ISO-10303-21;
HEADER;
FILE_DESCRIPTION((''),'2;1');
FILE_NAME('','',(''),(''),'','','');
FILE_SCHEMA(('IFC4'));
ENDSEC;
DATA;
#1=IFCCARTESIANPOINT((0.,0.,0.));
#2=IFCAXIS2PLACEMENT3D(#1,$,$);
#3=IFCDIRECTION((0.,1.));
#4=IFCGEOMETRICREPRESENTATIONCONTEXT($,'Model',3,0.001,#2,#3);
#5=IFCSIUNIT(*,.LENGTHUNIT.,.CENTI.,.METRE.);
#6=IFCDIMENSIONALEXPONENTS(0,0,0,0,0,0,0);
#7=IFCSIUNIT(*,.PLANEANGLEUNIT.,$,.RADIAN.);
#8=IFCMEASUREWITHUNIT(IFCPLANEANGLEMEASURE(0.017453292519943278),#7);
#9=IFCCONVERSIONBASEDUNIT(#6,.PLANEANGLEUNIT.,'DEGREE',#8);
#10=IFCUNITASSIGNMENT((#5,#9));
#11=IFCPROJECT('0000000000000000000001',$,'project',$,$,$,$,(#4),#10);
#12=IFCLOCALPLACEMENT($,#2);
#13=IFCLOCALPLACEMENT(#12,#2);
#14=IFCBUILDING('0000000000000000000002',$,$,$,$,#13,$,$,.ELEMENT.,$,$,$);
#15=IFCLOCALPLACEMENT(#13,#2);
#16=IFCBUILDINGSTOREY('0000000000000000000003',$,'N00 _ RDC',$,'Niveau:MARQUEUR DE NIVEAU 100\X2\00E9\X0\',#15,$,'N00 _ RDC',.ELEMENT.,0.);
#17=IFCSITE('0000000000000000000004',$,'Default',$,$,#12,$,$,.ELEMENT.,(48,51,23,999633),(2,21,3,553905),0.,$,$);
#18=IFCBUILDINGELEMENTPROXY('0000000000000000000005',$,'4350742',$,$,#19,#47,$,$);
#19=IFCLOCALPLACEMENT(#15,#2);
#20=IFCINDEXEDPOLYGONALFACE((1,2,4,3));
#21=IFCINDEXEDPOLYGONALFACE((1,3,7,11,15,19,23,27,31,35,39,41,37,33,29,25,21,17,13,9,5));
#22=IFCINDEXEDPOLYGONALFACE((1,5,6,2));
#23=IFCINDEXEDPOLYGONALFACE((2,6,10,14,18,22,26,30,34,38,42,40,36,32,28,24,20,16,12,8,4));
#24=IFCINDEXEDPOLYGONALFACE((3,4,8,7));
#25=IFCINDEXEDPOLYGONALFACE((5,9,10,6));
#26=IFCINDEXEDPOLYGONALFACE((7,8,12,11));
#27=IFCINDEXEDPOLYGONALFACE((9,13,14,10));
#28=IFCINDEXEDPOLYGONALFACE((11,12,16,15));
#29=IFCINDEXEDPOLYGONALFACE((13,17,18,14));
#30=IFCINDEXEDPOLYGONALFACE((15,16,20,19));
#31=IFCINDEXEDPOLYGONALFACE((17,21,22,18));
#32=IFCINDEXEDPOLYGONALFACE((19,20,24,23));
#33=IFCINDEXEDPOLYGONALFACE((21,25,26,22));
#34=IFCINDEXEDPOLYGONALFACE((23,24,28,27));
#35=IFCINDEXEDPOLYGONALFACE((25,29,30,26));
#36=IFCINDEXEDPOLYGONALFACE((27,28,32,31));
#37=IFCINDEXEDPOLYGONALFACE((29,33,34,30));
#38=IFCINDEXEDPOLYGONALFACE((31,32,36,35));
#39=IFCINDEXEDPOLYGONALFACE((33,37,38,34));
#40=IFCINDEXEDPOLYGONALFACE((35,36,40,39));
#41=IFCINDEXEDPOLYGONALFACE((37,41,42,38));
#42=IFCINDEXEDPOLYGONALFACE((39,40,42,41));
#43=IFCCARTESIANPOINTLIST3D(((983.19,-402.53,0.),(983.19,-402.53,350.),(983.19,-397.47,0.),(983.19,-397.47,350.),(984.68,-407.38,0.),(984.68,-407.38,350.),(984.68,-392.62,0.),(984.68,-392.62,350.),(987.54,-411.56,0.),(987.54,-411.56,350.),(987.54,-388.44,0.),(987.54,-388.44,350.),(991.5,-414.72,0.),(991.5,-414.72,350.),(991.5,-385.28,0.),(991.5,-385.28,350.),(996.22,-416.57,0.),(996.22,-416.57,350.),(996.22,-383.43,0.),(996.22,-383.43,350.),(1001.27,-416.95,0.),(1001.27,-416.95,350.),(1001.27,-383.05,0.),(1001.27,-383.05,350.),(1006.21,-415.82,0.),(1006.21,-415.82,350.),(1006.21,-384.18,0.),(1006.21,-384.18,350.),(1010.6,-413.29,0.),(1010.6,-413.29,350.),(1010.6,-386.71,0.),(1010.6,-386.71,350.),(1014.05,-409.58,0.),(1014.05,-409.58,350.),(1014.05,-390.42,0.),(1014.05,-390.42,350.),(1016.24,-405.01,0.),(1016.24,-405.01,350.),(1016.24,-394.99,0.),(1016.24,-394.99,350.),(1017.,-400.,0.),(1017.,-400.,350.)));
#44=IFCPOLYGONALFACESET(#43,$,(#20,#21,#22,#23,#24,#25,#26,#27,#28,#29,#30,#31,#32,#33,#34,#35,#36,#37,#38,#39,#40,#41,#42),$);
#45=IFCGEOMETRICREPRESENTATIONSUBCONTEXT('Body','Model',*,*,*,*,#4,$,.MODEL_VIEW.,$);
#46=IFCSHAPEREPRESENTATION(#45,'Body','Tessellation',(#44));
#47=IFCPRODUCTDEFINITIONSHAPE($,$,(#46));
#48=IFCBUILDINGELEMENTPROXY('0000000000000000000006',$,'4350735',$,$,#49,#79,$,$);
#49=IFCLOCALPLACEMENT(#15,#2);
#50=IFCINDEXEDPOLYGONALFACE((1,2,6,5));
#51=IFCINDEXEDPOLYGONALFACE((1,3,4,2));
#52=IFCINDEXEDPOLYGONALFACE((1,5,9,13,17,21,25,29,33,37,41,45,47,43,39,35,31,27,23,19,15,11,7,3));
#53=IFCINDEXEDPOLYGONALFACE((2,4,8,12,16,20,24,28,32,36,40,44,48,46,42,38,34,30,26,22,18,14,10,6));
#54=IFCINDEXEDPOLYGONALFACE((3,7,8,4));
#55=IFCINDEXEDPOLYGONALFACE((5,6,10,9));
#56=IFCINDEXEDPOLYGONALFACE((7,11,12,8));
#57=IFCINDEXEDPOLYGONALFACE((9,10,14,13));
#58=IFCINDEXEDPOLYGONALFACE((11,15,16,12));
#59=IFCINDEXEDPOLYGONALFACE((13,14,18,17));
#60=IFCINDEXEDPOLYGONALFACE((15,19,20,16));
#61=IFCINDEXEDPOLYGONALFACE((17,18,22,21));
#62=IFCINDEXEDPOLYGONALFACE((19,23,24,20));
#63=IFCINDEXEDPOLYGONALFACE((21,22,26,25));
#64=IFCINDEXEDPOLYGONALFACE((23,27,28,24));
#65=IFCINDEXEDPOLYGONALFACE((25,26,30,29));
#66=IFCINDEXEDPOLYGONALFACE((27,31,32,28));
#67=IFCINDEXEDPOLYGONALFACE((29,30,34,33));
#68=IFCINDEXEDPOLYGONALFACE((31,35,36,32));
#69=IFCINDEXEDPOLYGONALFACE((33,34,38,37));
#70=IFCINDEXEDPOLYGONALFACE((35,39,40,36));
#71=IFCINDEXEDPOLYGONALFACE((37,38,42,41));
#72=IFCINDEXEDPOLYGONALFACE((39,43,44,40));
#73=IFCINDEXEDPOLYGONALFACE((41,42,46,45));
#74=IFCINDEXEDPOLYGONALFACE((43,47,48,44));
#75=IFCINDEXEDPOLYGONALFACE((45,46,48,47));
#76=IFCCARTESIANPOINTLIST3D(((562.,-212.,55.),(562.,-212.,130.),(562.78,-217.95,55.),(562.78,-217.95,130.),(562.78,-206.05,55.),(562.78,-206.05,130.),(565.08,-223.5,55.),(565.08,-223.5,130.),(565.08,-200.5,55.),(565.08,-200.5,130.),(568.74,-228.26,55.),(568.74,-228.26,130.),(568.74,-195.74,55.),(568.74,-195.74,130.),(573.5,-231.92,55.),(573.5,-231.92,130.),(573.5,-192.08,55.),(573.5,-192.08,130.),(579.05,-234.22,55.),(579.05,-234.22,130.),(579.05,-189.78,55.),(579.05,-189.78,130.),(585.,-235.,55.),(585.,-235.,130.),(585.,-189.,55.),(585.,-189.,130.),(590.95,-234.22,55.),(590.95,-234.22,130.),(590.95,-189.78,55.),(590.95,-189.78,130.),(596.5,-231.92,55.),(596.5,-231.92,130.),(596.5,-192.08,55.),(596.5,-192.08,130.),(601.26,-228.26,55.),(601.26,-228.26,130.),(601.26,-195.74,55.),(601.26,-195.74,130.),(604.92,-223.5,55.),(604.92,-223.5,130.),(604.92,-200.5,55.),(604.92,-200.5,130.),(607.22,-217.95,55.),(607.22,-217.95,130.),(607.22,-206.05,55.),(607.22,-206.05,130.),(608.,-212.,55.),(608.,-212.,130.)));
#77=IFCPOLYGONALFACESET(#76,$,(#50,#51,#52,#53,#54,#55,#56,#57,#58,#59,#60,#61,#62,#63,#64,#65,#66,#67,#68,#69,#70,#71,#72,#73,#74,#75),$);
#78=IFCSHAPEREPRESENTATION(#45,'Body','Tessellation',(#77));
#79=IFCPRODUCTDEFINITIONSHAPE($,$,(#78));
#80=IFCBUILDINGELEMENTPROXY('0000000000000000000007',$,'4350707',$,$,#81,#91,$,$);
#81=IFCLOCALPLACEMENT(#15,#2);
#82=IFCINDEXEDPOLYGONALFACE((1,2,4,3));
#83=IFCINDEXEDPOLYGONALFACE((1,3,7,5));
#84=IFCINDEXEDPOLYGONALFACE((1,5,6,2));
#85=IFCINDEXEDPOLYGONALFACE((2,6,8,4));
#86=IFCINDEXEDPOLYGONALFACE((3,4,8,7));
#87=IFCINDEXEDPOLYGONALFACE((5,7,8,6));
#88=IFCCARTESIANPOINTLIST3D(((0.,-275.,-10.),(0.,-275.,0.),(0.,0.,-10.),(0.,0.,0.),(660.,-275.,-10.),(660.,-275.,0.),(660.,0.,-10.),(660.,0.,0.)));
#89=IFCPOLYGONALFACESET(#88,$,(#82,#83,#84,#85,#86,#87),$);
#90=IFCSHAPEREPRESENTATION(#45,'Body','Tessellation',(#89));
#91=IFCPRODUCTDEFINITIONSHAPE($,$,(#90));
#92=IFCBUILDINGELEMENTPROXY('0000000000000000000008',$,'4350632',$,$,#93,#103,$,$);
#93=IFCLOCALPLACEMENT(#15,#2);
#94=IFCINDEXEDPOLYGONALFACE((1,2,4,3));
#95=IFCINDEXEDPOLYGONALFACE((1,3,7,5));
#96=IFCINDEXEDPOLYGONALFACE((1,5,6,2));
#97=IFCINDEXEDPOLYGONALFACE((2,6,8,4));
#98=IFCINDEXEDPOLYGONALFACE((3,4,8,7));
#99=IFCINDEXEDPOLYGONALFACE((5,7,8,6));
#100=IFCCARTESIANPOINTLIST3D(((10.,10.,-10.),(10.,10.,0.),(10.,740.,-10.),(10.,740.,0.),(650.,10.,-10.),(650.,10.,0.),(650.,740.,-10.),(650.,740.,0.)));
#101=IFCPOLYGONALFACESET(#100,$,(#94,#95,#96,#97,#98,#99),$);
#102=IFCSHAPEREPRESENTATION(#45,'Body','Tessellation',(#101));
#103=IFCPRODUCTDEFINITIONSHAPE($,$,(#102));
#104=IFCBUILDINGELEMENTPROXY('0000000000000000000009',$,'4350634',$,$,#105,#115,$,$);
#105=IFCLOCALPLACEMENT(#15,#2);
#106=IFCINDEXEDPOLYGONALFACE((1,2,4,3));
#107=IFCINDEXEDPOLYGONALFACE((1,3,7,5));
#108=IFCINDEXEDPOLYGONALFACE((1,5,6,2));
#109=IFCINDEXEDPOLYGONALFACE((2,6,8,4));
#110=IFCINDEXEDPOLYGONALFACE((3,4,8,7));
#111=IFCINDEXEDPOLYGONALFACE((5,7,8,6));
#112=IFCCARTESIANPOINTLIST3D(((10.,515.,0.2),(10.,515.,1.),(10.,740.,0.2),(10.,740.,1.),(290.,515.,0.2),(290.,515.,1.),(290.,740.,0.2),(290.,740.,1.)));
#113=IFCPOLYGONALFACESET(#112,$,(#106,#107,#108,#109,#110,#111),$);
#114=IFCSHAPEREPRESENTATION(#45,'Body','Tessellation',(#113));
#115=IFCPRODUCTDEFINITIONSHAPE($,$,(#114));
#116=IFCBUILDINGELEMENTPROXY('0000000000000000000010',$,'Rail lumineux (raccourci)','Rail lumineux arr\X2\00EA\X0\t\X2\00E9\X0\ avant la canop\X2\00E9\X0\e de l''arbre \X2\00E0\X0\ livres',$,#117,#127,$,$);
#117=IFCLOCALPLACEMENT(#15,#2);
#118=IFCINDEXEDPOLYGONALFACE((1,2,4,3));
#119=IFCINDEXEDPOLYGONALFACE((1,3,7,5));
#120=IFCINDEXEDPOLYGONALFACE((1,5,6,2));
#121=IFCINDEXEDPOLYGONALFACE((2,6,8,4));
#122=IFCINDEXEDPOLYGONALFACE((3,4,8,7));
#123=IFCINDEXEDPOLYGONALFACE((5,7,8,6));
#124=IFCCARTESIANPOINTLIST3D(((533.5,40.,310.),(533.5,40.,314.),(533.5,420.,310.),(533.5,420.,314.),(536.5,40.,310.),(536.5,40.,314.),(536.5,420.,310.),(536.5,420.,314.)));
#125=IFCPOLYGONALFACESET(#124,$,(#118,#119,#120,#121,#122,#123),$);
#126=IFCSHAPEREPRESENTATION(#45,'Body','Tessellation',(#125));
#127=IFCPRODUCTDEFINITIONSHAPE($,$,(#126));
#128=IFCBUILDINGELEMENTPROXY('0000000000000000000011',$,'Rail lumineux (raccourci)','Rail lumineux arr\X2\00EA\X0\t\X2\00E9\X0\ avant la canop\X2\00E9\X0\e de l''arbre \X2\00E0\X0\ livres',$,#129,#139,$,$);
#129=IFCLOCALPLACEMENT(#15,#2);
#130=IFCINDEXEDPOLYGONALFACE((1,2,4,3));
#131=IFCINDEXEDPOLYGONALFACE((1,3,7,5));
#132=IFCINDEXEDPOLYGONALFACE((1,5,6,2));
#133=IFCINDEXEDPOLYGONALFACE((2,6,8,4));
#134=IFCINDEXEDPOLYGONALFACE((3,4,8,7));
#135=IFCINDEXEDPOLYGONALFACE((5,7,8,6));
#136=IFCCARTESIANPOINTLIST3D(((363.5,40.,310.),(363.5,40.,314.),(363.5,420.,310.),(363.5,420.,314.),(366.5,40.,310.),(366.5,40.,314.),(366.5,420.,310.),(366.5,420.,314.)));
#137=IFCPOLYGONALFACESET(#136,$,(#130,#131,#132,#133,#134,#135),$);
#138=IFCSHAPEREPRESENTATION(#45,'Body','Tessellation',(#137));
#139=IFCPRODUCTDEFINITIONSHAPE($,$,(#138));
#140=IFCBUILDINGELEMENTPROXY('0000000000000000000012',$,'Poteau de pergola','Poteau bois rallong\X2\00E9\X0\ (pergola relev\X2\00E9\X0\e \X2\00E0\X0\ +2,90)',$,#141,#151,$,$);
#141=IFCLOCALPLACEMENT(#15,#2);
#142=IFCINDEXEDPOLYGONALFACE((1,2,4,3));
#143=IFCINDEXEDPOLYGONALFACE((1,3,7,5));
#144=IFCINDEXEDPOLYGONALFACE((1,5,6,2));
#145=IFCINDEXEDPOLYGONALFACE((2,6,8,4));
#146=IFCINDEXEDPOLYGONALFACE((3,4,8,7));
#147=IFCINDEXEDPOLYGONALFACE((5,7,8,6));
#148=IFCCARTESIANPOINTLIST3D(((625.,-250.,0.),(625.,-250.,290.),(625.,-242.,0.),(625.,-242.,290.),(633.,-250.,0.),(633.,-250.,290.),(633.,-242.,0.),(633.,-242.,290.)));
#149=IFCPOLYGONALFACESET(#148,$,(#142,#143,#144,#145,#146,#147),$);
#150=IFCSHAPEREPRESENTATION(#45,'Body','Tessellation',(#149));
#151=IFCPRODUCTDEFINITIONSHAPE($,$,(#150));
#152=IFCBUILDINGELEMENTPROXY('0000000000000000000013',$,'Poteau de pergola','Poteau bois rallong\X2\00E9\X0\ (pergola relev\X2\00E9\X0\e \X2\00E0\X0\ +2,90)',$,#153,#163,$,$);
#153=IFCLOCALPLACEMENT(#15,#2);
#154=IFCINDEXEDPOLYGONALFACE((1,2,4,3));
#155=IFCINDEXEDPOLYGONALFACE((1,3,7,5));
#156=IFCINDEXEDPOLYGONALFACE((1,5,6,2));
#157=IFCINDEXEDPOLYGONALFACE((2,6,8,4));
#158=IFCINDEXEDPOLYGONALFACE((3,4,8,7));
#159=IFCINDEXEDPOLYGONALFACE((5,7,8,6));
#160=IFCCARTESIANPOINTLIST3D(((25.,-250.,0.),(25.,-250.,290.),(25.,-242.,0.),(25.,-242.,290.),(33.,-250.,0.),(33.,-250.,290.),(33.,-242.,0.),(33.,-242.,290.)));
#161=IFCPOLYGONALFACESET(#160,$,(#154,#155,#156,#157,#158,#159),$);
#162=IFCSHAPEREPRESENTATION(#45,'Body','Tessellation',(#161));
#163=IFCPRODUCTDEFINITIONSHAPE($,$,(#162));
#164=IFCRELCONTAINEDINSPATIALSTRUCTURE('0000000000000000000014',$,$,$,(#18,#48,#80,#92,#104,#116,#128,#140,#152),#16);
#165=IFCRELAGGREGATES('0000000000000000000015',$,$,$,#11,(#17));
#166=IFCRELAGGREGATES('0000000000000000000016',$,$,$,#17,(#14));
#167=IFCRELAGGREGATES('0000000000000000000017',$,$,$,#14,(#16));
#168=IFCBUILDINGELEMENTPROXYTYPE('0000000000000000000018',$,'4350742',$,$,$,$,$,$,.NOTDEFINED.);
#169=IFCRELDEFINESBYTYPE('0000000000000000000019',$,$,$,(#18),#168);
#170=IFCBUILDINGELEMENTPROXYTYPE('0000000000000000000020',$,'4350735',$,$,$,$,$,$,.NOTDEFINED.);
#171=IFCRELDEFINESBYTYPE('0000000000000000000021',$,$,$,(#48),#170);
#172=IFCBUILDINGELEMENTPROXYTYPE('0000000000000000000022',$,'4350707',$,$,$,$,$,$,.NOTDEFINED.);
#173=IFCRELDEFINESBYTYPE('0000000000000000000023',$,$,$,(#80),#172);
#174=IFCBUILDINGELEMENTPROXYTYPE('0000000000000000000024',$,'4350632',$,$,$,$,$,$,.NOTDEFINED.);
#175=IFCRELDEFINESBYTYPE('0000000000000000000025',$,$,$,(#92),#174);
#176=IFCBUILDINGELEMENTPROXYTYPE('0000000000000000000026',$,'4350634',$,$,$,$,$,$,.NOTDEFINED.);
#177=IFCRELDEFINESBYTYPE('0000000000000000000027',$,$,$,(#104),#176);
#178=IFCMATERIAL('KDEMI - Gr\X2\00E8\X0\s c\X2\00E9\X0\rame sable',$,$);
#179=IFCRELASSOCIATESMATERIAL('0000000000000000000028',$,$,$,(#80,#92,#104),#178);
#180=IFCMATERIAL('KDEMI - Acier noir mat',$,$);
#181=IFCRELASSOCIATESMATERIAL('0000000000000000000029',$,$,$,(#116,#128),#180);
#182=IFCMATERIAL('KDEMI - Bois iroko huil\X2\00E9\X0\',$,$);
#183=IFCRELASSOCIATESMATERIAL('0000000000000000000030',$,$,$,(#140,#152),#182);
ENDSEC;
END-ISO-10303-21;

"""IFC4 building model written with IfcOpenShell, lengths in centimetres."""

from ifc_helpers import new_model, entity, si_unit, converted_unit, direction, frame, frame_2d, origin, origin_with_axes, origin_2d_with_axis, place, context, subcontext, project, spatial, rectangle, circle, extrude, material, type_object, element, save


model = new_model("IFC4")

# Units and contexts
model_context = context("Model", 3, precision=0.001, world=origin(), true_north=direction((0.0, 1.0)))
body_context = subcontext(model_context, "Body", "Model", "MODEL_VIEW")
ifc_project = project(units=[si_unit("LENGTHUNIT", "METRE", prefix="CENTI"), converted_unit("PLANEANGLEUNIT", "DEGREE", entity("IfcPlaneAngleMeasure", 0.017453292519943278), si_unit("PLANEANGLEUNIT", "RADIAN"), dimensions=[0, 0, 0, 0, 0, 0, 0])], contexts=[model_context])

# Site, building, storey
site_placement = place(None, origin())
site = spatial("IfcSite", under=ifc_project, at=site_placement, Name="Default", CompositionType="ELEMENT", RefLatitude=(48, 51, 23, 999633), RefLongitude=(2, 21, 3, 553905), RefElevation=0.0)
building_placement = place(site_placement, origin())
building = spatial("IfcBuilding", under=site, at=building_placement, CompositionType="ELEMENT")
storey_placement = place(building_placement, origin())
storey = spatial("IfcBuildingStorey", under=building, at=storey_placement, Name="N00 _ RDC", ObjectType="Niveau:MARQUEUR DE NIVEAU 100é", LongName="N00 _ RDC", CompositionType="ELEMENT", Elevation=0.0)

# Building element proxies
building_element_proxy_type_1 = type_object("IfcBuildingElementProxyType", Name="4350742", PredefinedType="NOTDEFINED")
proxy_1_placement = place(storey_placement, origin())
element("IfcBuildingElementProxy", 1, at=proxy_1_placement, inside=storey, type_object=building_element_proxy_type_1, Name="4350742", context=body_context, shape_type="SweptSolid", body=[
    extrude(circle(Radius=17.0, at=origin_2d_with_axis()), frame((1000.0, -400.0, 0.0)), (0.0, 0.0, 1.0), 350.0),
])
building_element_proxy_type_2 = type_object("IfcBuildingElementProxyType", Name="4350735", PredefinedType="NOTDEFINED")
proxy_2_placement = place(storey_placement, origin())
element("IfcBuildingElementProxy", 2, at=proxy_2_placement, inside=storey, type_object=building_element_proxy_type_2, Name="4350735", context=body_context, shape_type="SweptSolid", body=[
    extrude(circle(Radius=23.0, at=origin_2d_with_axis()), frame((585.0, -212.0, 55.0)), (0.0, 0.0, 1.0), 75.0),
])
ifc_material_1 = material(Name="KDEMI - Grès cérame sable")
building_element_proxy_type_3 = type_object("IfcBuildingElementProxyType", Name="4350707", PredefinedType="NOTDEFINED")
proxy_3_placement = place(storey_placement, origin())
element("IfcBuildingElementProxy", 3, at=proxy_3_placement, inside=storey, type_object=building_element_proxy_type_3, material=ifc_material_1, Name="4350707", context=body_context, shape_type="SweptSolid", body=[
    extrude(rectangle(XDim=660.0, YDim=275.0, at=origin_2d_with_axis()), frame((330.0, -137.5, -10.0)), (0.0, 0.0, 1.0), 10.0),
])
building_element_proxy_type_4 = type_object("IfcBuildingElementProxyType", Name="4350632", PredefinedType="NOTDEFINED")
proxy_4_placement = place(storey_placement, origin())
element("IfcBuildingElementProxy", 4, at=proxy_4_placement, inside=storey, type_object=building_element_proxy_type_4, material=ifc_material_1, Name="4350632", context=body_context, shape_type="SweptSolid", body=[
    extrude(rectangle(XDim=640.0, YDim=730.0, at=origin_2d_with_axis()), frame((330.0, 375.0, -10.0)), (0.0, 0.0, 1.0), 10.0),
])
building_element_proxy_type_5 = type_object("IfcBuildingElementProxyType", Name="4350634", PredefinedType="NOTDEFINED")
proxy_5_placement = place(storey_placement, origin())
element("IfcBuildingElementProxy", 5, at=proxy_5_placement, inside=storey, type_object=building_element_proxy_type_5, material=ifc_material_1, Name="4350634", context=body_context, shape_type="SweptSolid", body=[
    extrude(rectangle(XDim=280.0, YDim=225.0, at=frame_2d((0.0, 0.0), x_axis=(1.0, 0.0))), frame((150.0, 627.5, 0.2)), (0.0, 0.0, 1.0), 0.8),
])
ifc_material_2 = material(Name="KDEMI - Acier noir mat")
proxy_6_placement = place(storey_placement, origin_with_axes())
element("IfcBuildingElementProxy", 6, at=proxy_6_placement, inside=storey, material=ifc_material_2, Name="Rail lumineux (raccourci)", Description="Rail lumineux arrêté avant la canopée de l'arbre à livres", context=body_context, shape_type="SweptSolid", body=[
    extrude(rectangle(XDim=3.0, YDim=380.0, at=frame_2d((535.0, 230.0))), frame((0.0, 0.0, 310.0)), (0.0, 0.0, 1.0), 4.0),
])
proxy_7_placement = place(storey_placement, origin_with_axes())
element("IfcBuildingElementProxy", 7, at=proxy_7_placement, inside=storey, material=ifc_material_2, Name="Rail lumineux (raccourci)", Description="Rail lumineux arrêté avant la canopée de l'arbre à livres", context=body_context, shape_type="SweptSolid", body=[
    extrude(rectangle(XDim=3.0, YDim=380.0, at=frame_2d((365.0, 230.0))), frame((0.0, 0.0, 310.0)), (0.0, 0.0, 1.0), 4.0),
])
ifc_material_3 = material(Name="KDEMI - Bois iroko huilé")
proxy_8_placement = place(storey_placement, origin_with_axes())
element("IfcBuildingElementProxy", 8, at=proxy_8_placement, inside=storey, material=ifc_material_3, Name="Poteau de pergola", Description="Poteau bois rallongé (pergola relevée à +2,90)", context=body_context, shape_type="SweptSolid", body=[
    extrude(rectangle(XDim=8.0, YDim=8.0, at=frame_2d((629.0, -246.0))), origin(), (0.0, 0.0, 1.0), 290.0),
])
proxy_9_placement = place(storey_placement, origin_with_axes())
element("IfcBuildingElementProxy", 9, at=proxy_9_placement, inside=storey, material=ifc_material_3, Name="Poteau de pergola", Description="Poteau bois rallongé (pergola relevée à +2,90)", context=body_context, shape_type="SweptSolid", body=[
    extrude(rectangle(XDim=8.0, YDim=8.0, at=frame_2d((29.0, -246.0))), origin(), (0.0, 0.0, 1.0), 290.0),
])

save(model, "model.ifc")
